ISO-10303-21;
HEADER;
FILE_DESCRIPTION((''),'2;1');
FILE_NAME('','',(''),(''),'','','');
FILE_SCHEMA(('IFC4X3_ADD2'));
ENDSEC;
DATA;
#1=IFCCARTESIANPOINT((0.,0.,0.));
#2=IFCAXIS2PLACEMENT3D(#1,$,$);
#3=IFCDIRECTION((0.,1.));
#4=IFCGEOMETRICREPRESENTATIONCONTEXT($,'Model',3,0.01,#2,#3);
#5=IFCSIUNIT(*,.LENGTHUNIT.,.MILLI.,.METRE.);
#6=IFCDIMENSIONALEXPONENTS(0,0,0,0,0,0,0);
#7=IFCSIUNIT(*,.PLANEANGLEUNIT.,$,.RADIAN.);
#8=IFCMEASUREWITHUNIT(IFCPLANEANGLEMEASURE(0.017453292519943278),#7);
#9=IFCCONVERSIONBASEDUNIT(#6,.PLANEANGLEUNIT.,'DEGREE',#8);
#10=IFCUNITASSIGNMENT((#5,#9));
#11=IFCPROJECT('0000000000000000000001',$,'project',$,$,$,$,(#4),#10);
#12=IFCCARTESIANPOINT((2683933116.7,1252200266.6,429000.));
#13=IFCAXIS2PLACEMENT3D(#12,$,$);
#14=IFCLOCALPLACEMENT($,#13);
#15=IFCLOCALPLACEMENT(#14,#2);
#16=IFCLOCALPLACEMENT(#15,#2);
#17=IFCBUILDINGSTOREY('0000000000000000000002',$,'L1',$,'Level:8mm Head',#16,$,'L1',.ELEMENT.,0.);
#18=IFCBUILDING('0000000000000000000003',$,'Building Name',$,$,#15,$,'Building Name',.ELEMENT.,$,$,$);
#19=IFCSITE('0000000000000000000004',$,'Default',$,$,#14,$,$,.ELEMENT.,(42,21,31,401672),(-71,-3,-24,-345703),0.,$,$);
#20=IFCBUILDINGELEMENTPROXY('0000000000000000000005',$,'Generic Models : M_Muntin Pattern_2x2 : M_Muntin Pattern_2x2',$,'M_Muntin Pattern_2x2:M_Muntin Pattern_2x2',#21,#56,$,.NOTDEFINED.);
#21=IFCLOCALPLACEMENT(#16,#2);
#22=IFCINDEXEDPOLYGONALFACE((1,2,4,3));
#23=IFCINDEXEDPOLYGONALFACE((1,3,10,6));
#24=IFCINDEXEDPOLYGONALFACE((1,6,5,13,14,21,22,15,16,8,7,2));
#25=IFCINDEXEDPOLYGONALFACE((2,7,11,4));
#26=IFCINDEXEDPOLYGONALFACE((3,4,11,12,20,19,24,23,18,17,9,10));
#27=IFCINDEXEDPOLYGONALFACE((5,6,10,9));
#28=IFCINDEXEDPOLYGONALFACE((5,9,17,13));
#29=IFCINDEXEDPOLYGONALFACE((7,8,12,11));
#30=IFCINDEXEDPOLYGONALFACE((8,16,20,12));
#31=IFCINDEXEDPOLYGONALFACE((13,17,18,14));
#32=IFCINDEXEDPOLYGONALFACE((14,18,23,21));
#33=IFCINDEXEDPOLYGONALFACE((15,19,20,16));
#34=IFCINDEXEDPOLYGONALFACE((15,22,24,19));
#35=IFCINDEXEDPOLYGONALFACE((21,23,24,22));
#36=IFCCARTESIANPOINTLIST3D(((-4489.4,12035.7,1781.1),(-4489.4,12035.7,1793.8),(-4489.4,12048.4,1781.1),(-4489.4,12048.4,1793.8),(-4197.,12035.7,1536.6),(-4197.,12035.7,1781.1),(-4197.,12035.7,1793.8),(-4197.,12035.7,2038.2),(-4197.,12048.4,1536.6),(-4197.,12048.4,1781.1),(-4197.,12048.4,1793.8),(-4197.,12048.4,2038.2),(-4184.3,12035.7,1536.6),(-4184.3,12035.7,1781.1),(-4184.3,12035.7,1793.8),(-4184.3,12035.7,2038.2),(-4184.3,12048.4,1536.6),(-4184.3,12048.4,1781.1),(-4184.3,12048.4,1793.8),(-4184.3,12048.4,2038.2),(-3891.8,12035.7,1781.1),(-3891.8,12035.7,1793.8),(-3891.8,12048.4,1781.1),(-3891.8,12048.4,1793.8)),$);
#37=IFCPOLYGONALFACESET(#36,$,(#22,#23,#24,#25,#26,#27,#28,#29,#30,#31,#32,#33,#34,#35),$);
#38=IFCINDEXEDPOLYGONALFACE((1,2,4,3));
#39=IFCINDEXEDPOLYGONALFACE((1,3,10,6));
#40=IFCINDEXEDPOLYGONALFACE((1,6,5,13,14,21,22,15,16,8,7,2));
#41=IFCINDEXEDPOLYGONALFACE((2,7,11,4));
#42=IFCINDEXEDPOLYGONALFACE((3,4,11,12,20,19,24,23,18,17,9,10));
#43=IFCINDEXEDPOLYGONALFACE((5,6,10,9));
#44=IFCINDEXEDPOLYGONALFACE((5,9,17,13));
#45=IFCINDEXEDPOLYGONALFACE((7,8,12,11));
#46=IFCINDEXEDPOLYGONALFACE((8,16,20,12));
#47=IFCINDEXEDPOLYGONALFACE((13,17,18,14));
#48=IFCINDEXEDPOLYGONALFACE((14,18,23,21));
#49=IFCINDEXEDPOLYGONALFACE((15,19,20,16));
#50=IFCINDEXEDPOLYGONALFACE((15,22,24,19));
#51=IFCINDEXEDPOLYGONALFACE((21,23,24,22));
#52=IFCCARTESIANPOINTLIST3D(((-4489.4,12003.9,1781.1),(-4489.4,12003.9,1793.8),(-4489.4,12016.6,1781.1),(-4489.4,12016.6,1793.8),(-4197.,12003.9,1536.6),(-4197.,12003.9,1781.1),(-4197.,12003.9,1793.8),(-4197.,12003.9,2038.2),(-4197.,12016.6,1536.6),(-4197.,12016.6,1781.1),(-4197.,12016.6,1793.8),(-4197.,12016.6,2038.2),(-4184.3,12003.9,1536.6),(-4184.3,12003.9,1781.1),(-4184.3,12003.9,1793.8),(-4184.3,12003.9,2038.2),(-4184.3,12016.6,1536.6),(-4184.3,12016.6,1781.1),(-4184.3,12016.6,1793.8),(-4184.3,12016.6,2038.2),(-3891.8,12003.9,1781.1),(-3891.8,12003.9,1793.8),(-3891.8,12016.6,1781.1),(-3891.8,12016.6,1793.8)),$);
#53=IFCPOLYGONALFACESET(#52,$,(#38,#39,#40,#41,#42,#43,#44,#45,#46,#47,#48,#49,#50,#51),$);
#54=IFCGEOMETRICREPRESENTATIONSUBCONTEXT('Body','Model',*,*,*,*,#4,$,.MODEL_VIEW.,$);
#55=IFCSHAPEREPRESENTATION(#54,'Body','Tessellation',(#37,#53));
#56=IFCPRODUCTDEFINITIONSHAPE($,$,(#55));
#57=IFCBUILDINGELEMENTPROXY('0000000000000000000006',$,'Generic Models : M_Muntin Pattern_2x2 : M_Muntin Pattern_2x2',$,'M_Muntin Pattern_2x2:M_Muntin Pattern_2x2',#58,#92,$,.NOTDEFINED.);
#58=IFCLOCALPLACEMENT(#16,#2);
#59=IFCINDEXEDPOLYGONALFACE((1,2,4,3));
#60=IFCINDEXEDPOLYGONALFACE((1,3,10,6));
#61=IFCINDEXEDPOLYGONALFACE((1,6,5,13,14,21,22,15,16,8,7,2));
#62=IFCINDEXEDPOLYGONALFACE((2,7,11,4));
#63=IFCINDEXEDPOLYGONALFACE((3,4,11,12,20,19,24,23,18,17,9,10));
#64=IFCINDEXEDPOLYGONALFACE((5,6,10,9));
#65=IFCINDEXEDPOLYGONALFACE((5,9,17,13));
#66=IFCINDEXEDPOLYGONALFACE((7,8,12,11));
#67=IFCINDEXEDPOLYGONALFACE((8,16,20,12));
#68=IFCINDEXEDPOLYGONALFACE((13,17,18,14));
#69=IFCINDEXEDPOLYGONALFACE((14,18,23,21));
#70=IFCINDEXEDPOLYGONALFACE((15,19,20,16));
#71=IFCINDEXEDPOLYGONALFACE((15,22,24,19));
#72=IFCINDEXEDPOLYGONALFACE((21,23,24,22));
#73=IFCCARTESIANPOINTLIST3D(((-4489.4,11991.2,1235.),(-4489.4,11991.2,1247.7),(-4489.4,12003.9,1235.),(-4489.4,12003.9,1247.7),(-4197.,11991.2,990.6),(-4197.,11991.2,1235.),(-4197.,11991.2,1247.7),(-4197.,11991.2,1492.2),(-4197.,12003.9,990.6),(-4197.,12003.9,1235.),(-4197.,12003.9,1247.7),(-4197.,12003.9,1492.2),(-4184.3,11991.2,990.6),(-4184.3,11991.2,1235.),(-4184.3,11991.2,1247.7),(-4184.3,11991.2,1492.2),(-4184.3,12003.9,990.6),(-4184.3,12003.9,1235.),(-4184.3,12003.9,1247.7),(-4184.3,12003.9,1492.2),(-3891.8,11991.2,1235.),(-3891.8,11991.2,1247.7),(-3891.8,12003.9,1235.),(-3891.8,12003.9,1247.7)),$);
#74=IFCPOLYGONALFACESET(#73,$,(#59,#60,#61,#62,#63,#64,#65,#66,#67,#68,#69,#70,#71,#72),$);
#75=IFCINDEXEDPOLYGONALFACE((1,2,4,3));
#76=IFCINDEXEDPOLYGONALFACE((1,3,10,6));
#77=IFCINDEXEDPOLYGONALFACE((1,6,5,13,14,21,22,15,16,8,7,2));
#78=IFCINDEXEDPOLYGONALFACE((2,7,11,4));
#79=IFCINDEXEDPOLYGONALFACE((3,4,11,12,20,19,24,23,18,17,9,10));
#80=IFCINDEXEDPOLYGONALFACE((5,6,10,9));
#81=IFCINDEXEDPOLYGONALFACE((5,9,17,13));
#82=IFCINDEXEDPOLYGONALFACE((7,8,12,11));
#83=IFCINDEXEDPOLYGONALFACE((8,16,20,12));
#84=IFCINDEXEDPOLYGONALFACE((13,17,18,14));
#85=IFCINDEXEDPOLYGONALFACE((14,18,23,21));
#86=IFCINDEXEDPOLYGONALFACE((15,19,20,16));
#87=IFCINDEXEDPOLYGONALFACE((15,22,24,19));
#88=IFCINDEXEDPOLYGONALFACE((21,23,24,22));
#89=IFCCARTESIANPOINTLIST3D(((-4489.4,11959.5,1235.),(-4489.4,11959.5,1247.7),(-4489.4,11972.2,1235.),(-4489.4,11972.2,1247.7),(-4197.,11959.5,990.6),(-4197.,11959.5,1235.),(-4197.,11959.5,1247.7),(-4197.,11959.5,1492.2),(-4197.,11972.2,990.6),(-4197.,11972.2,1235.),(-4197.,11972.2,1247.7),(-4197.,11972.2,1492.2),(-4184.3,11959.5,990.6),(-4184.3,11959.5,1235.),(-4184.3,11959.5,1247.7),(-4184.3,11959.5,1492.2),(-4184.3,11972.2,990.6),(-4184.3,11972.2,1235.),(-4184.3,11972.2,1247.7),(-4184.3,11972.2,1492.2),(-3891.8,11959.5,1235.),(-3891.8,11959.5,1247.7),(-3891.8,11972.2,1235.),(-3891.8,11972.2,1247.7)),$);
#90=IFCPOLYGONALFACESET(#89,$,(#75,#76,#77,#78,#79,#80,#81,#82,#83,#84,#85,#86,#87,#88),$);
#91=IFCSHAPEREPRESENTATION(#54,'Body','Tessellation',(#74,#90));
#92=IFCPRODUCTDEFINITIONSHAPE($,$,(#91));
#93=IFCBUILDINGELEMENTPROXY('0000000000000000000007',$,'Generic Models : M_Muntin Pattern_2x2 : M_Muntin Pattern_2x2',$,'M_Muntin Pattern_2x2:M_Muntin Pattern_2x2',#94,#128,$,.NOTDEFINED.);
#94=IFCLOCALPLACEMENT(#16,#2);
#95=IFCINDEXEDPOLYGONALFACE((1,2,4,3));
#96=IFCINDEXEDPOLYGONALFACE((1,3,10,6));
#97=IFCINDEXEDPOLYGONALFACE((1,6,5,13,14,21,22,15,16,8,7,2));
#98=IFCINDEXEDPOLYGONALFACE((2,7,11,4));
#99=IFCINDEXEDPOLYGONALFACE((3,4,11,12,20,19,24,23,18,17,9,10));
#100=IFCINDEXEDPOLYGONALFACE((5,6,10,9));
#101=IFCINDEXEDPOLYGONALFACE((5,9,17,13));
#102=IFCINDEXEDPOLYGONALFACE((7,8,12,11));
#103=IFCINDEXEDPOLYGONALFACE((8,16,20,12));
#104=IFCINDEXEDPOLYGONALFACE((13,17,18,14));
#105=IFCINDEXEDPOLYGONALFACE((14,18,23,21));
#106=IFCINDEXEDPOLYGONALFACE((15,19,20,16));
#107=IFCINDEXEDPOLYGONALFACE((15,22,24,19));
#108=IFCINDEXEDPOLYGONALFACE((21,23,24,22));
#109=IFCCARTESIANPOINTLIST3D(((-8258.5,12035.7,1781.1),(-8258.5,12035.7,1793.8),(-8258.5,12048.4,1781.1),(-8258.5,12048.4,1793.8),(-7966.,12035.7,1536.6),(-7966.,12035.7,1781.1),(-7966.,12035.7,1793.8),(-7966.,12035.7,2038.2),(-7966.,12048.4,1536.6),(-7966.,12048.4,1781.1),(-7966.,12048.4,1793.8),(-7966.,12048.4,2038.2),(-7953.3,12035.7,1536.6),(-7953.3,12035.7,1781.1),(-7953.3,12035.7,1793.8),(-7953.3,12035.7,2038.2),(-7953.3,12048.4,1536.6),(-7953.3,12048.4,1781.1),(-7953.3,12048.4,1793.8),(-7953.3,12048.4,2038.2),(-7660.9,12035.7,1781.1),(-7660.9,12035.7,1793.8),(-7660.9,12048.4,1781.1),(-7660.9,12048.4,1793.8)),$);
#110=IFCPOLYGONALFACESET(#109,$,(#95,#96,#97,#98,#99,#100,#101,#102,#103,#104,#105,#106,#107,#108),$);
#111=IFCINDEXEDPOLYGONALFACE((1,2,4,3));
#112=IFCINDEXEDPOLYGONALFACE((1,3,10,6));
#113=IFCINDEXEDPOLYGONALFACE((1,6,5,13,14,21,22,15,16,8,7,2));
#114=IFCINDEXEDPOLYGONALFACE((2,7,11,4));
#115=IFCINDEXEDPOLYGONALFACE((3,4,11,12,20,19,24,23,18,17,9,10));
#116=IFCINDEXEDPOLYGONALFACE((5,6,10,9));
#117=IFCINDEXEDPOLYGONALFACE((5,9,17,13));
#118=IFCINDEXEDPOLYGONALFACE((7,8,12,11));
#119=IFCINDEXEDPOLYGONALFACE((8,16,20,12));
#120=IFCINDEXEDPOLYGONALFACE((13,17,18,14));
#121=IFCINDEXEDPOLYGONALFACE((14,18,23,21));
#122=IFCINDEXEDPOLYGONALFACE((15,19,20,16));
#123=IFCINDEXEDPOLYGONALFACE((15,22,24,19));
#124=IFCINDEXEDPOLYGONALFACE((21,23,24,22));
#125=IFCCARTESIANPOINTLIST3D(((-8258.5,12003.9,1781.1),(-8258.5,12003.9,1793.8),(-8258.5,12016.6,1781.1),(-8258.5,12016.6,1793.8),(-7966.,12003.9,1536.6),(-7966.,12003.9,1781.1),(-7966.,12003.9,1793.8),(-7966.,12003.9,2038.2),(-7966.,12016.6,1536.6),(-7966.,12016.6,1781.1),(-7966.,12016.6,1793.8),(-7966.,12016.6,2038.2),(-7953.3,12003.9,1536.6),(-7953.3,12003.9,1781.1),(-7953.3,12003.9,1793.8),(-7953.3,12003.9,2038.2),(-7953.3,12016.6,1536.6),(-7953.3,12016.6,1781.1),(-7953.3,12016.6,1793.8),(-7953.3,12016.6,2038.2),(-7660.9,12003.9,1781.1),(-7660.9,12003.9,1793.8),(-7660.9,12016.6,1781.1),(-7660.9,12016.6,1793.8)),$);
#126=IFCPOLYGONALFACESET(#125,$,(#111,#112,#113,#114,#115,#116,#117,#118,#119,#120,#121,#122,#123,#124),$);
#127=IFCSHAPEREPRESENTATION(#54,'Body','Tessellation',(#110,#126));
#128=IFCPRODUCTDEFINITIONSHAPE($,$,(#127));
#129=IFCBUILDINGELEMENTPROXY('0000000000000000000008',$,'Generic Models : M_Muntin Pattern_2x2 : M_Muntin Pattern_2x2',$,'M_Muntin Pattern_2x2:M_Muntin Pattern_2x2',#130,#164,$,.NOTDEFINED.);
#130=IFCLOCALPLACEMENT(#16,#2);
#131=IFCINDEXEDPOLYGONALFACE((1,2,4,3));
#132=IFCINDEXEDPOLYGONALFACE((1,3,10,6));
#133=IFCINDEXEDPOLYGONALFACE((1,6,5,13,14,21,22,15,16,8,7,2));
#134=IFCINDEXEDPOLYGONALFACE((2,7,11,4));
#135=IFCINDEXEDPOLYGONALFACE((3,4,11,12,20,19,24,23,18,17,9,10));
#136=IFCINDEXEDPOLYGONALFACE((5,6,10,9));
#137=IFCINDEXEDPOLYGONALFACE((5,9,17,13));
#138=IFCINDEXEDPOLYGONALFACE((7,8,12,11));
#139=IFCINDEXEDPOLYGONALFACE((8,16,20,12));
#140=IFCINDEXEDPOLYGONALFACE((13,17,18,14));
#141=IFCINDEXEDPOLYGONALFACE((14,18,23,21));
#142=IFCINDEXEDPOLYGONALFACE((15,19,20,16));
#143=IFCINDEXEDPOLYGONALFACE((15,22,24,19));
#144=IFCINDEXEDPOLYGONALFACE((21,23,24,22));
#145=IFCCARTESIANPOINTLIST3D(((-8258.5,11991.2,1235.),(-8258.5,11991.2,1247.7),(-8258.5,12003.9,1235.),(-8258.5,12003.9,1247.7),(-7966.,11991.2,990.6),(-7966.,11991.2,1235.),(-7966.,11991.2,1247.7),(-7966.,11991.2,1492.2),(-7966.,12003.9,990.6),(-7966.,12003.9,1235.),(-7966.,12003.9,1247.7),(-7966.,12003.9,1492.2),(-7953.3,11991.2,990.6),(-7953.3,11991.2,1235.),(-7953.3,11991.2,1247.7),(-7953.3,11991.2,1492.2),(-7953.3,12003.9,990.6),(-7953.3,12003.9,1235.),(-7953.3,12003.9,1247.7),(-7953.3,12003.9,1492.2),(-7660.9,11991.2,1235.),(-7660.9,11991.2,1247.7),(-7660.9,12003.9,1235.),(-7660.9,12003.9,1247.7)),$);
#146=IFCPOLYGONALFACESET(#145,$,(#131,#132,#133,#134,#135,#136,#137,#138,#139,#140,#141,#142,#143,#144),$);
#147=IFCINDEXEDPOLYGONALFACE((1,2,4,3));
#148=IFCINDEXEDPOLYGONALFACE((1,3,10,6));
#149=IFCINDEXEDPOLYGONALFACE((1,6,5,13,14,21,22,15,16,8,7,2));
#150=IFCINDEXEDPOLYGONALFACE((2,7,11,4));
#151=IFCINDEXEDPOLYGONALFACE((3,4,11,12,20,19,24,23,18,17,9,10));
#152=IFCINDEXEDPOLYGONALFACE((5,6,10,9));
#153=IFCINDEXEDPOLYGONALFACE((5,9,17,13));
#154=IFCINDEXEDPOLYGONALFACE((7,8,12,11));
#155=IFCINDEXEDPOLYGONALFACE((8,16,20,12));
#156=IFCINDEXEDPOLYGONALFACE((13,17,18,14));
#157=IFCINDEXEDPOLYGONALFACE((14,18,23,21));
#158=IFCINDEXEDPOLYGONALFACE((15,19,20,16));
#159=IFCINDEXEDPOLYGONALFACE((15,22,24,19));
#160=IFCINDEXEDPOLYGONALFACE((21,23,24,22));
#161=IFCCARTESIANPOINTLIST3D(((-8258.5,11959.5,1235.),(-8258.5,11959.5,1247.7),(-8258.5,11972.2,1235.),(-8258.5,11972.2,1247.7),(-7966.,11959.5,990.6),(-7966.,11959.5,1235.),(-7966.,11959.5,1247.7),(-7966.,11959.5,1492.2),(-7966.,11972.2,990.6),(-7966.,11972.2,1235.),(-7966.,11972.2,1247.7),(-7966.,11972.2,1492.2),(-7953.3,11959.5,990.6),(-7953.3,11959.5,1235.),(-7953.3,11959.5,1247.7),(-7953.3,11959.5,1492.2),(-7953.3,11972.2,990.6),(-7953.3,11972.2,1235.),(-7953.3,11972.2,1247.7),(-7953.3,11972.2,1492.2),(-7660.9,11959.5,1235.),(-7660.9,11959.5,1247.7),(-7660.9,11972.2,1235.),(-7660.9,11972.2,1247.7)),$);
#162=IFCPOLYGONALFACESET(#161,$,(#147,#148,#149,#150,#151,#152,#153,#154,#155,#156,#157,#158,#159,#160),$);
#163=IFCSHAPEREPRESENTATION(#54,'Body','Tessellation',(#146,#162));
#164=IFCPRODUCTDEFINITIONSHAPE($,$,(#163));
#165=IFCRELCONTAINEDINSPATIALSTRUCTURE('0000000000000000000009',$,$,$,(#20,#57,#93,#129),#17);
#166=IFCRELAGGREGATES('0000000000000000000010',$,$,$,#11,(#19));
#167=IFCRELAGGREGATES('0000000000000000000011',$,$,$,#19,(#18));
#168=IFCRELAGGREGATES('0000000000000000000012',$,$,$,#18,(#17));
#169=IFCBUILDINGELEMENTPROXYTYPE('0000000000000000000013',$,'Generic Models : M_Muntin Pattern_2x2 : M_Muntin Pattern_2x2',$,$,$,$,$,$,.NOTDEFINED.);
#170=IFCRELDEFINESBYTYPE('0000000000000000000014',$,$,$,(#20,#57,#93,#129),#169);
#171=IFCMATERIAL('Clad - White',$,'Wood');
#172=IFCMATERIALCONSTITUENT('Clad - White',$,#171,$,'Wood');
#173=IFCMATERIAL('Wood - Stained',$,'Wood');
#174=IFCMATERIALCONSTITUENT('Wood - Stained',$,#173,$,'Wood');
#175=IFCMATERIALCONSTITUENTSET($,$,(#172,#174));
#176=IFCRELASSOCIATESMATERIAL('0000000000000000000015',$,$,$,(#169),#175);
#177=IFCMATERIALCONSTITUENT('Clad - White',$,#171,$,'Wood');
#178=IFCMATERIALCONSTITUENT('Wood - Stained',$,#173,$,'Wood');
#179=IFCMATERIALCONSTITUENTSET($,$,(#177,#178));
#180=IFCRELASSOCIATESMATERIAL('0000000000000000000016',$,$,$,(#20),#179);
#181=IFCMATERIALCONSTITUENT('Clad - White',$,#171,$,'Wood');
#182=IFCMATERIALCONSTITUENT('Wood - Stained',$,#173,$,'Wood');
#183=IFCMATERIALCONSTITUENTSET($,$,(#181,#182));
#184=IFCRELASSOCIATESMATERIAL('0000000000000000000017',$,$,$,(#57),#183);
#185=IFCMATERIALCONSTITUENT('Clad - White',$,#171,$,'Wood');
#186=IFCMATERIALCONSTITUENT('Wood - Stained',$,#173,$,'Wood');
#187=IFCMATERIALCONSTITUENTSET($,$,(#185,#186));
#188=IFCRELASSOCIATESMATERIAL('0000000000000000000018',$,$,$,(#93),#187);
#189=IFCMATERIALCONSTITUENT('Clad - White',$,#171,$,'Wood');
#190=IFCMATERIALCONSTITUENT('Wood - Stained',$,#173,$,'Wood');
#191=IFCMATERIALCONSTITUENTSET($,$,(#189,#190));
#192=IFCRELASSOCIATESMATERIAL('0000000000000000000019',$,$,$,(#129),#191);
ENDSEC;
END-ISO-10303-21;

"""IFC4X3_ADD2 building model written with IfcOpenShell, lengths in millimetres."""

from ifc_helpers import new_model, entity, si_unit, converted_unit, direction, frame, origin, place, context, subcontext, project, spatial, polyline, outline, extrude, source, transform, mapped, material, constituent, constituent_set, type_object, type_shapes, element, save


model = new_model("IFC4X3_ADD2")

# Units and contexts
model_context = context("Model", 3, precision=0.01, world=origin(), true_north=direction((0.0, 1.0)))
body_context = subcontext(model_context, "Body", "Model", "MODEL_VIEW")
ifc_project = project(units=[si_unit("LENGTHUNIT", "METRE", prefix="MILLI"), converted_unit("PLANEANGLEUNIT", "DEGREE", entity("IfcPlaneAngleMeasure", 0.017453292519943278), si_unit("PLANEANGLEUNIT", "RADIAN"), dimensions=[0, 0, 0, 0, 0, 0, 0])], contexts=[model_context])

# Site, building, storey
site_placement = place(None, frame((2683933116.7, 1252200266.6, 429000.0)))
site = spatial("IfcSite", under=ifc_project, at=site_placement, Name="Default", CompositionType="ELEMENT", RefLatitude=(42, 21, 31, 401672), RefLongitude=(-71, -3, -24, -345703), RefElevation=0.0)
building_placement = place(site_placement, origin())
building = spatial("IfcBuilding", under=site, at=building_placement, Name="Building Name", LongName="Building Name", CompositionType="ELEMENT")
storey_placement = place(building_placement, origin())
storey = spatial("IfcBuildingStorey", under=building, at=storey_placement, Name="L1", ObjectType="Level:8mm Head", LongName="L1", CompositionType="ELEMENT", Elevation=0.0)

# Shared definitions
ifc_material_1 = material(Name="Wood - Stained", Category="Wood")

# Building element proxies
ifc_material_2 = material(Name="Clad - White", Category="Wood")
ifc_constituent_1 = constituent(ifc_material_2, Name="Clad - White", Category="Wood")
ifc_constituent_2 = constituent(ifc_material_1, Name="Wood - Stained", Category="Wood")
ifc_constituent_set_1 = constituent_set(constituents=[ifc_constituent_1, ifc_constituent_2])
building_element_proxy_type_1 = type_object("IfcBuildingElementProxyType", Name="Generic Models : M_Muntin Pattern_2x2 : M_Muntin Pattern_2x2", PredefinedType="NOTDEFINED", material=ifc_constituent_set_1)
shared_shape_1 = source(origin(), body_context, "Body", "SweptSolid", [
    extrude(outline(polyline([(6.4, -6.4), (250.8, -6.4), (250.8, 6.3), (6.4, 6.3), (6.4, 298.8), (-6.3, 298.8), (-6.3, 6.3), (-250.8, 6.3), (-250.8, -6.4), (-6.3, -6.4), (-6.3, -298.8), (6.4, -298.8), (6.4, -6.4)])), frame((0.0, 9.5, 250.8), z_axis=(0.0, 1.0, 0.0), x_axis=(0.0, 0.0, 1.0)), (0.0, 0.0, 1.0), 12.7),
    extrude(outline(polyline([(6.4, -6.4), (250.8, -6.4), (250.8, 6.3), (6.4, 6.3), (6.4, 298.8), (-6.3, 298.8), (-6.3, 6.3), (-250.8, 6.3), (-250.8, -6.4), (-6.3, -6.4), (-6.3, -298.8), (6.4, -298.8), (6.4, -6.4)])), frame((0.0, -22.2, 250.8), z_axis=(0.0, 1.0, 0.0), x_axis=(0.0, 0.0, 1.0)), (0.0, 0.0, 1.0), 12.7),
])
type_shapes(building_element_proxy_type_1, [shared_shape_1])
ifc_constituent_3 = constituent(ifc_material_2, Name="Clad - White", Category="Wood")
ifc_constituent_4 = constituent(ifc_material_1, Name="Wood - Stained", Category="Wood")
ifc_constituent_set_2 = constituent_set(constituents=[ifc_constituent_3, ifc_constituent_4])
proxy_1_placement = place(storey_placement, frame((-4190.6, 12026.1, 1536.6)))
element("IfcBuildingElementProxy", 1, at=proxy_1_placement, inside=storey, type_object=building_element_proxy_type_1, material=ifc_constituent_set_2, Name="Generic Models : M_Muntin Pattern_2x2 : M_Muntin Pattern_2x2", ObjectType="M_Muntin Pattern_2x2:M_Muntin Pattern_2x2", PredefinedType="NOTDEFINED", context=body_context, shape_type="MappedRepresentation", body=[
    mapped(shared_shape_1, transform((0.0, 0.0, 0.0), scale=1.0)),
])
ifc_constituent_5 = constituent(ifc_material_2, Name="Clad - White", Category="Wood")
ifc_constituent_6 = constituent(ifc_material_1, Name="Wood - Stained", Category="Wood")
ifc_constituent_set_3 = constituent_set(constituents=[ifc_constituent_5, ifc_constituent_6])
proxy_2_placement = place(storey_placement, frame((-4190.6, 11981.7, 990.6)))
element("IfcBuildingElementProxy", 2, at=proxy_2_placement, inside=storey, type_object=building_element_proxy_type_1, material=ifc_constituent_set_3, Name="Generic Models : M_Muntin Pattern_2x2 : M_Muntin Pattern_2x2", ObjectType="M_Muntin Pattern_2x2:M_Muntin Pattern_2x2", PredefinedType="NOTDEFINED", context=body_context, shape_type="MappedRepresentation", body=[
    mapped(shared_shape_1, transform((0.0, 0.0, 0.0), scale=1.0)),
])
ifc_constituent_7 = constituent(ifc_material_2, Name="Clad - White", Category="Wood")
ifc_constituent_8 = constituent(ifc_material_1, Name="Wood - Stained", Category="Wood")
ifc_constituent_set_4 = constituent_set(constituents=[ifc_constituent_7, ifc_constituent_8])
proxy_3_placement = place(storey_placement, frame((-7959.7, 12026.1, 1536.6)))
element("IfcBuildingElementProxy", 3, at=proxy_3_placement, inside=storey, type_object=building_element_proxy_type_1, material=ifc_constituent_set_4, Name="Generic Models : M_Muntin Pattern_2x2 : M_Muntin Pattern_2x2", ObjectType="M_Muntin Pattern_2x2:M_Muntin Pattern_2x2", PredefinedType="NOTDEFINED", context=body_context, shape_type="MappedRepresentation", body=[
    mapped(shared_shape_1, transform((0.0, 0.0, 0.0), scale=1.0)),
])
ifc_constituent_9 = constituent(ifc_material_2, Name="Clad - White", Category="Wood")
ifc_constituent_10 = constituent(ifc_material_1, Name="Wood - Stained", Category="Wood")
ifc_constituent_set_5 = constituent_set(constituents=[ifc_constituent_9, ifc_constituent_10])
proxy_4_placement = place(storey_placement, frame((-7959.7, 11981.7, 990.6)))
element("IfcBuildingElementProxy", 4, at=proxy_4_placement, inside=storey, type_object=building_element_proxy_type_1, material=ifc_constituent_set_5, Name="Generic Models : M_Muntin Pattern_2x2 : M_Muntin Pattern_2x2", ObjectType="M_Muntin Pattern_2x2:M_Muntin Pattern_2x2", PredefinedType="NOTDEFINED", context=body_context, shape_type="MappedRepresentation", body=[
    mapped(shared_shape_1, transform((0.0, 0.0, 0.0), scale=1.0)),
])

save(model, "model.ifc")
